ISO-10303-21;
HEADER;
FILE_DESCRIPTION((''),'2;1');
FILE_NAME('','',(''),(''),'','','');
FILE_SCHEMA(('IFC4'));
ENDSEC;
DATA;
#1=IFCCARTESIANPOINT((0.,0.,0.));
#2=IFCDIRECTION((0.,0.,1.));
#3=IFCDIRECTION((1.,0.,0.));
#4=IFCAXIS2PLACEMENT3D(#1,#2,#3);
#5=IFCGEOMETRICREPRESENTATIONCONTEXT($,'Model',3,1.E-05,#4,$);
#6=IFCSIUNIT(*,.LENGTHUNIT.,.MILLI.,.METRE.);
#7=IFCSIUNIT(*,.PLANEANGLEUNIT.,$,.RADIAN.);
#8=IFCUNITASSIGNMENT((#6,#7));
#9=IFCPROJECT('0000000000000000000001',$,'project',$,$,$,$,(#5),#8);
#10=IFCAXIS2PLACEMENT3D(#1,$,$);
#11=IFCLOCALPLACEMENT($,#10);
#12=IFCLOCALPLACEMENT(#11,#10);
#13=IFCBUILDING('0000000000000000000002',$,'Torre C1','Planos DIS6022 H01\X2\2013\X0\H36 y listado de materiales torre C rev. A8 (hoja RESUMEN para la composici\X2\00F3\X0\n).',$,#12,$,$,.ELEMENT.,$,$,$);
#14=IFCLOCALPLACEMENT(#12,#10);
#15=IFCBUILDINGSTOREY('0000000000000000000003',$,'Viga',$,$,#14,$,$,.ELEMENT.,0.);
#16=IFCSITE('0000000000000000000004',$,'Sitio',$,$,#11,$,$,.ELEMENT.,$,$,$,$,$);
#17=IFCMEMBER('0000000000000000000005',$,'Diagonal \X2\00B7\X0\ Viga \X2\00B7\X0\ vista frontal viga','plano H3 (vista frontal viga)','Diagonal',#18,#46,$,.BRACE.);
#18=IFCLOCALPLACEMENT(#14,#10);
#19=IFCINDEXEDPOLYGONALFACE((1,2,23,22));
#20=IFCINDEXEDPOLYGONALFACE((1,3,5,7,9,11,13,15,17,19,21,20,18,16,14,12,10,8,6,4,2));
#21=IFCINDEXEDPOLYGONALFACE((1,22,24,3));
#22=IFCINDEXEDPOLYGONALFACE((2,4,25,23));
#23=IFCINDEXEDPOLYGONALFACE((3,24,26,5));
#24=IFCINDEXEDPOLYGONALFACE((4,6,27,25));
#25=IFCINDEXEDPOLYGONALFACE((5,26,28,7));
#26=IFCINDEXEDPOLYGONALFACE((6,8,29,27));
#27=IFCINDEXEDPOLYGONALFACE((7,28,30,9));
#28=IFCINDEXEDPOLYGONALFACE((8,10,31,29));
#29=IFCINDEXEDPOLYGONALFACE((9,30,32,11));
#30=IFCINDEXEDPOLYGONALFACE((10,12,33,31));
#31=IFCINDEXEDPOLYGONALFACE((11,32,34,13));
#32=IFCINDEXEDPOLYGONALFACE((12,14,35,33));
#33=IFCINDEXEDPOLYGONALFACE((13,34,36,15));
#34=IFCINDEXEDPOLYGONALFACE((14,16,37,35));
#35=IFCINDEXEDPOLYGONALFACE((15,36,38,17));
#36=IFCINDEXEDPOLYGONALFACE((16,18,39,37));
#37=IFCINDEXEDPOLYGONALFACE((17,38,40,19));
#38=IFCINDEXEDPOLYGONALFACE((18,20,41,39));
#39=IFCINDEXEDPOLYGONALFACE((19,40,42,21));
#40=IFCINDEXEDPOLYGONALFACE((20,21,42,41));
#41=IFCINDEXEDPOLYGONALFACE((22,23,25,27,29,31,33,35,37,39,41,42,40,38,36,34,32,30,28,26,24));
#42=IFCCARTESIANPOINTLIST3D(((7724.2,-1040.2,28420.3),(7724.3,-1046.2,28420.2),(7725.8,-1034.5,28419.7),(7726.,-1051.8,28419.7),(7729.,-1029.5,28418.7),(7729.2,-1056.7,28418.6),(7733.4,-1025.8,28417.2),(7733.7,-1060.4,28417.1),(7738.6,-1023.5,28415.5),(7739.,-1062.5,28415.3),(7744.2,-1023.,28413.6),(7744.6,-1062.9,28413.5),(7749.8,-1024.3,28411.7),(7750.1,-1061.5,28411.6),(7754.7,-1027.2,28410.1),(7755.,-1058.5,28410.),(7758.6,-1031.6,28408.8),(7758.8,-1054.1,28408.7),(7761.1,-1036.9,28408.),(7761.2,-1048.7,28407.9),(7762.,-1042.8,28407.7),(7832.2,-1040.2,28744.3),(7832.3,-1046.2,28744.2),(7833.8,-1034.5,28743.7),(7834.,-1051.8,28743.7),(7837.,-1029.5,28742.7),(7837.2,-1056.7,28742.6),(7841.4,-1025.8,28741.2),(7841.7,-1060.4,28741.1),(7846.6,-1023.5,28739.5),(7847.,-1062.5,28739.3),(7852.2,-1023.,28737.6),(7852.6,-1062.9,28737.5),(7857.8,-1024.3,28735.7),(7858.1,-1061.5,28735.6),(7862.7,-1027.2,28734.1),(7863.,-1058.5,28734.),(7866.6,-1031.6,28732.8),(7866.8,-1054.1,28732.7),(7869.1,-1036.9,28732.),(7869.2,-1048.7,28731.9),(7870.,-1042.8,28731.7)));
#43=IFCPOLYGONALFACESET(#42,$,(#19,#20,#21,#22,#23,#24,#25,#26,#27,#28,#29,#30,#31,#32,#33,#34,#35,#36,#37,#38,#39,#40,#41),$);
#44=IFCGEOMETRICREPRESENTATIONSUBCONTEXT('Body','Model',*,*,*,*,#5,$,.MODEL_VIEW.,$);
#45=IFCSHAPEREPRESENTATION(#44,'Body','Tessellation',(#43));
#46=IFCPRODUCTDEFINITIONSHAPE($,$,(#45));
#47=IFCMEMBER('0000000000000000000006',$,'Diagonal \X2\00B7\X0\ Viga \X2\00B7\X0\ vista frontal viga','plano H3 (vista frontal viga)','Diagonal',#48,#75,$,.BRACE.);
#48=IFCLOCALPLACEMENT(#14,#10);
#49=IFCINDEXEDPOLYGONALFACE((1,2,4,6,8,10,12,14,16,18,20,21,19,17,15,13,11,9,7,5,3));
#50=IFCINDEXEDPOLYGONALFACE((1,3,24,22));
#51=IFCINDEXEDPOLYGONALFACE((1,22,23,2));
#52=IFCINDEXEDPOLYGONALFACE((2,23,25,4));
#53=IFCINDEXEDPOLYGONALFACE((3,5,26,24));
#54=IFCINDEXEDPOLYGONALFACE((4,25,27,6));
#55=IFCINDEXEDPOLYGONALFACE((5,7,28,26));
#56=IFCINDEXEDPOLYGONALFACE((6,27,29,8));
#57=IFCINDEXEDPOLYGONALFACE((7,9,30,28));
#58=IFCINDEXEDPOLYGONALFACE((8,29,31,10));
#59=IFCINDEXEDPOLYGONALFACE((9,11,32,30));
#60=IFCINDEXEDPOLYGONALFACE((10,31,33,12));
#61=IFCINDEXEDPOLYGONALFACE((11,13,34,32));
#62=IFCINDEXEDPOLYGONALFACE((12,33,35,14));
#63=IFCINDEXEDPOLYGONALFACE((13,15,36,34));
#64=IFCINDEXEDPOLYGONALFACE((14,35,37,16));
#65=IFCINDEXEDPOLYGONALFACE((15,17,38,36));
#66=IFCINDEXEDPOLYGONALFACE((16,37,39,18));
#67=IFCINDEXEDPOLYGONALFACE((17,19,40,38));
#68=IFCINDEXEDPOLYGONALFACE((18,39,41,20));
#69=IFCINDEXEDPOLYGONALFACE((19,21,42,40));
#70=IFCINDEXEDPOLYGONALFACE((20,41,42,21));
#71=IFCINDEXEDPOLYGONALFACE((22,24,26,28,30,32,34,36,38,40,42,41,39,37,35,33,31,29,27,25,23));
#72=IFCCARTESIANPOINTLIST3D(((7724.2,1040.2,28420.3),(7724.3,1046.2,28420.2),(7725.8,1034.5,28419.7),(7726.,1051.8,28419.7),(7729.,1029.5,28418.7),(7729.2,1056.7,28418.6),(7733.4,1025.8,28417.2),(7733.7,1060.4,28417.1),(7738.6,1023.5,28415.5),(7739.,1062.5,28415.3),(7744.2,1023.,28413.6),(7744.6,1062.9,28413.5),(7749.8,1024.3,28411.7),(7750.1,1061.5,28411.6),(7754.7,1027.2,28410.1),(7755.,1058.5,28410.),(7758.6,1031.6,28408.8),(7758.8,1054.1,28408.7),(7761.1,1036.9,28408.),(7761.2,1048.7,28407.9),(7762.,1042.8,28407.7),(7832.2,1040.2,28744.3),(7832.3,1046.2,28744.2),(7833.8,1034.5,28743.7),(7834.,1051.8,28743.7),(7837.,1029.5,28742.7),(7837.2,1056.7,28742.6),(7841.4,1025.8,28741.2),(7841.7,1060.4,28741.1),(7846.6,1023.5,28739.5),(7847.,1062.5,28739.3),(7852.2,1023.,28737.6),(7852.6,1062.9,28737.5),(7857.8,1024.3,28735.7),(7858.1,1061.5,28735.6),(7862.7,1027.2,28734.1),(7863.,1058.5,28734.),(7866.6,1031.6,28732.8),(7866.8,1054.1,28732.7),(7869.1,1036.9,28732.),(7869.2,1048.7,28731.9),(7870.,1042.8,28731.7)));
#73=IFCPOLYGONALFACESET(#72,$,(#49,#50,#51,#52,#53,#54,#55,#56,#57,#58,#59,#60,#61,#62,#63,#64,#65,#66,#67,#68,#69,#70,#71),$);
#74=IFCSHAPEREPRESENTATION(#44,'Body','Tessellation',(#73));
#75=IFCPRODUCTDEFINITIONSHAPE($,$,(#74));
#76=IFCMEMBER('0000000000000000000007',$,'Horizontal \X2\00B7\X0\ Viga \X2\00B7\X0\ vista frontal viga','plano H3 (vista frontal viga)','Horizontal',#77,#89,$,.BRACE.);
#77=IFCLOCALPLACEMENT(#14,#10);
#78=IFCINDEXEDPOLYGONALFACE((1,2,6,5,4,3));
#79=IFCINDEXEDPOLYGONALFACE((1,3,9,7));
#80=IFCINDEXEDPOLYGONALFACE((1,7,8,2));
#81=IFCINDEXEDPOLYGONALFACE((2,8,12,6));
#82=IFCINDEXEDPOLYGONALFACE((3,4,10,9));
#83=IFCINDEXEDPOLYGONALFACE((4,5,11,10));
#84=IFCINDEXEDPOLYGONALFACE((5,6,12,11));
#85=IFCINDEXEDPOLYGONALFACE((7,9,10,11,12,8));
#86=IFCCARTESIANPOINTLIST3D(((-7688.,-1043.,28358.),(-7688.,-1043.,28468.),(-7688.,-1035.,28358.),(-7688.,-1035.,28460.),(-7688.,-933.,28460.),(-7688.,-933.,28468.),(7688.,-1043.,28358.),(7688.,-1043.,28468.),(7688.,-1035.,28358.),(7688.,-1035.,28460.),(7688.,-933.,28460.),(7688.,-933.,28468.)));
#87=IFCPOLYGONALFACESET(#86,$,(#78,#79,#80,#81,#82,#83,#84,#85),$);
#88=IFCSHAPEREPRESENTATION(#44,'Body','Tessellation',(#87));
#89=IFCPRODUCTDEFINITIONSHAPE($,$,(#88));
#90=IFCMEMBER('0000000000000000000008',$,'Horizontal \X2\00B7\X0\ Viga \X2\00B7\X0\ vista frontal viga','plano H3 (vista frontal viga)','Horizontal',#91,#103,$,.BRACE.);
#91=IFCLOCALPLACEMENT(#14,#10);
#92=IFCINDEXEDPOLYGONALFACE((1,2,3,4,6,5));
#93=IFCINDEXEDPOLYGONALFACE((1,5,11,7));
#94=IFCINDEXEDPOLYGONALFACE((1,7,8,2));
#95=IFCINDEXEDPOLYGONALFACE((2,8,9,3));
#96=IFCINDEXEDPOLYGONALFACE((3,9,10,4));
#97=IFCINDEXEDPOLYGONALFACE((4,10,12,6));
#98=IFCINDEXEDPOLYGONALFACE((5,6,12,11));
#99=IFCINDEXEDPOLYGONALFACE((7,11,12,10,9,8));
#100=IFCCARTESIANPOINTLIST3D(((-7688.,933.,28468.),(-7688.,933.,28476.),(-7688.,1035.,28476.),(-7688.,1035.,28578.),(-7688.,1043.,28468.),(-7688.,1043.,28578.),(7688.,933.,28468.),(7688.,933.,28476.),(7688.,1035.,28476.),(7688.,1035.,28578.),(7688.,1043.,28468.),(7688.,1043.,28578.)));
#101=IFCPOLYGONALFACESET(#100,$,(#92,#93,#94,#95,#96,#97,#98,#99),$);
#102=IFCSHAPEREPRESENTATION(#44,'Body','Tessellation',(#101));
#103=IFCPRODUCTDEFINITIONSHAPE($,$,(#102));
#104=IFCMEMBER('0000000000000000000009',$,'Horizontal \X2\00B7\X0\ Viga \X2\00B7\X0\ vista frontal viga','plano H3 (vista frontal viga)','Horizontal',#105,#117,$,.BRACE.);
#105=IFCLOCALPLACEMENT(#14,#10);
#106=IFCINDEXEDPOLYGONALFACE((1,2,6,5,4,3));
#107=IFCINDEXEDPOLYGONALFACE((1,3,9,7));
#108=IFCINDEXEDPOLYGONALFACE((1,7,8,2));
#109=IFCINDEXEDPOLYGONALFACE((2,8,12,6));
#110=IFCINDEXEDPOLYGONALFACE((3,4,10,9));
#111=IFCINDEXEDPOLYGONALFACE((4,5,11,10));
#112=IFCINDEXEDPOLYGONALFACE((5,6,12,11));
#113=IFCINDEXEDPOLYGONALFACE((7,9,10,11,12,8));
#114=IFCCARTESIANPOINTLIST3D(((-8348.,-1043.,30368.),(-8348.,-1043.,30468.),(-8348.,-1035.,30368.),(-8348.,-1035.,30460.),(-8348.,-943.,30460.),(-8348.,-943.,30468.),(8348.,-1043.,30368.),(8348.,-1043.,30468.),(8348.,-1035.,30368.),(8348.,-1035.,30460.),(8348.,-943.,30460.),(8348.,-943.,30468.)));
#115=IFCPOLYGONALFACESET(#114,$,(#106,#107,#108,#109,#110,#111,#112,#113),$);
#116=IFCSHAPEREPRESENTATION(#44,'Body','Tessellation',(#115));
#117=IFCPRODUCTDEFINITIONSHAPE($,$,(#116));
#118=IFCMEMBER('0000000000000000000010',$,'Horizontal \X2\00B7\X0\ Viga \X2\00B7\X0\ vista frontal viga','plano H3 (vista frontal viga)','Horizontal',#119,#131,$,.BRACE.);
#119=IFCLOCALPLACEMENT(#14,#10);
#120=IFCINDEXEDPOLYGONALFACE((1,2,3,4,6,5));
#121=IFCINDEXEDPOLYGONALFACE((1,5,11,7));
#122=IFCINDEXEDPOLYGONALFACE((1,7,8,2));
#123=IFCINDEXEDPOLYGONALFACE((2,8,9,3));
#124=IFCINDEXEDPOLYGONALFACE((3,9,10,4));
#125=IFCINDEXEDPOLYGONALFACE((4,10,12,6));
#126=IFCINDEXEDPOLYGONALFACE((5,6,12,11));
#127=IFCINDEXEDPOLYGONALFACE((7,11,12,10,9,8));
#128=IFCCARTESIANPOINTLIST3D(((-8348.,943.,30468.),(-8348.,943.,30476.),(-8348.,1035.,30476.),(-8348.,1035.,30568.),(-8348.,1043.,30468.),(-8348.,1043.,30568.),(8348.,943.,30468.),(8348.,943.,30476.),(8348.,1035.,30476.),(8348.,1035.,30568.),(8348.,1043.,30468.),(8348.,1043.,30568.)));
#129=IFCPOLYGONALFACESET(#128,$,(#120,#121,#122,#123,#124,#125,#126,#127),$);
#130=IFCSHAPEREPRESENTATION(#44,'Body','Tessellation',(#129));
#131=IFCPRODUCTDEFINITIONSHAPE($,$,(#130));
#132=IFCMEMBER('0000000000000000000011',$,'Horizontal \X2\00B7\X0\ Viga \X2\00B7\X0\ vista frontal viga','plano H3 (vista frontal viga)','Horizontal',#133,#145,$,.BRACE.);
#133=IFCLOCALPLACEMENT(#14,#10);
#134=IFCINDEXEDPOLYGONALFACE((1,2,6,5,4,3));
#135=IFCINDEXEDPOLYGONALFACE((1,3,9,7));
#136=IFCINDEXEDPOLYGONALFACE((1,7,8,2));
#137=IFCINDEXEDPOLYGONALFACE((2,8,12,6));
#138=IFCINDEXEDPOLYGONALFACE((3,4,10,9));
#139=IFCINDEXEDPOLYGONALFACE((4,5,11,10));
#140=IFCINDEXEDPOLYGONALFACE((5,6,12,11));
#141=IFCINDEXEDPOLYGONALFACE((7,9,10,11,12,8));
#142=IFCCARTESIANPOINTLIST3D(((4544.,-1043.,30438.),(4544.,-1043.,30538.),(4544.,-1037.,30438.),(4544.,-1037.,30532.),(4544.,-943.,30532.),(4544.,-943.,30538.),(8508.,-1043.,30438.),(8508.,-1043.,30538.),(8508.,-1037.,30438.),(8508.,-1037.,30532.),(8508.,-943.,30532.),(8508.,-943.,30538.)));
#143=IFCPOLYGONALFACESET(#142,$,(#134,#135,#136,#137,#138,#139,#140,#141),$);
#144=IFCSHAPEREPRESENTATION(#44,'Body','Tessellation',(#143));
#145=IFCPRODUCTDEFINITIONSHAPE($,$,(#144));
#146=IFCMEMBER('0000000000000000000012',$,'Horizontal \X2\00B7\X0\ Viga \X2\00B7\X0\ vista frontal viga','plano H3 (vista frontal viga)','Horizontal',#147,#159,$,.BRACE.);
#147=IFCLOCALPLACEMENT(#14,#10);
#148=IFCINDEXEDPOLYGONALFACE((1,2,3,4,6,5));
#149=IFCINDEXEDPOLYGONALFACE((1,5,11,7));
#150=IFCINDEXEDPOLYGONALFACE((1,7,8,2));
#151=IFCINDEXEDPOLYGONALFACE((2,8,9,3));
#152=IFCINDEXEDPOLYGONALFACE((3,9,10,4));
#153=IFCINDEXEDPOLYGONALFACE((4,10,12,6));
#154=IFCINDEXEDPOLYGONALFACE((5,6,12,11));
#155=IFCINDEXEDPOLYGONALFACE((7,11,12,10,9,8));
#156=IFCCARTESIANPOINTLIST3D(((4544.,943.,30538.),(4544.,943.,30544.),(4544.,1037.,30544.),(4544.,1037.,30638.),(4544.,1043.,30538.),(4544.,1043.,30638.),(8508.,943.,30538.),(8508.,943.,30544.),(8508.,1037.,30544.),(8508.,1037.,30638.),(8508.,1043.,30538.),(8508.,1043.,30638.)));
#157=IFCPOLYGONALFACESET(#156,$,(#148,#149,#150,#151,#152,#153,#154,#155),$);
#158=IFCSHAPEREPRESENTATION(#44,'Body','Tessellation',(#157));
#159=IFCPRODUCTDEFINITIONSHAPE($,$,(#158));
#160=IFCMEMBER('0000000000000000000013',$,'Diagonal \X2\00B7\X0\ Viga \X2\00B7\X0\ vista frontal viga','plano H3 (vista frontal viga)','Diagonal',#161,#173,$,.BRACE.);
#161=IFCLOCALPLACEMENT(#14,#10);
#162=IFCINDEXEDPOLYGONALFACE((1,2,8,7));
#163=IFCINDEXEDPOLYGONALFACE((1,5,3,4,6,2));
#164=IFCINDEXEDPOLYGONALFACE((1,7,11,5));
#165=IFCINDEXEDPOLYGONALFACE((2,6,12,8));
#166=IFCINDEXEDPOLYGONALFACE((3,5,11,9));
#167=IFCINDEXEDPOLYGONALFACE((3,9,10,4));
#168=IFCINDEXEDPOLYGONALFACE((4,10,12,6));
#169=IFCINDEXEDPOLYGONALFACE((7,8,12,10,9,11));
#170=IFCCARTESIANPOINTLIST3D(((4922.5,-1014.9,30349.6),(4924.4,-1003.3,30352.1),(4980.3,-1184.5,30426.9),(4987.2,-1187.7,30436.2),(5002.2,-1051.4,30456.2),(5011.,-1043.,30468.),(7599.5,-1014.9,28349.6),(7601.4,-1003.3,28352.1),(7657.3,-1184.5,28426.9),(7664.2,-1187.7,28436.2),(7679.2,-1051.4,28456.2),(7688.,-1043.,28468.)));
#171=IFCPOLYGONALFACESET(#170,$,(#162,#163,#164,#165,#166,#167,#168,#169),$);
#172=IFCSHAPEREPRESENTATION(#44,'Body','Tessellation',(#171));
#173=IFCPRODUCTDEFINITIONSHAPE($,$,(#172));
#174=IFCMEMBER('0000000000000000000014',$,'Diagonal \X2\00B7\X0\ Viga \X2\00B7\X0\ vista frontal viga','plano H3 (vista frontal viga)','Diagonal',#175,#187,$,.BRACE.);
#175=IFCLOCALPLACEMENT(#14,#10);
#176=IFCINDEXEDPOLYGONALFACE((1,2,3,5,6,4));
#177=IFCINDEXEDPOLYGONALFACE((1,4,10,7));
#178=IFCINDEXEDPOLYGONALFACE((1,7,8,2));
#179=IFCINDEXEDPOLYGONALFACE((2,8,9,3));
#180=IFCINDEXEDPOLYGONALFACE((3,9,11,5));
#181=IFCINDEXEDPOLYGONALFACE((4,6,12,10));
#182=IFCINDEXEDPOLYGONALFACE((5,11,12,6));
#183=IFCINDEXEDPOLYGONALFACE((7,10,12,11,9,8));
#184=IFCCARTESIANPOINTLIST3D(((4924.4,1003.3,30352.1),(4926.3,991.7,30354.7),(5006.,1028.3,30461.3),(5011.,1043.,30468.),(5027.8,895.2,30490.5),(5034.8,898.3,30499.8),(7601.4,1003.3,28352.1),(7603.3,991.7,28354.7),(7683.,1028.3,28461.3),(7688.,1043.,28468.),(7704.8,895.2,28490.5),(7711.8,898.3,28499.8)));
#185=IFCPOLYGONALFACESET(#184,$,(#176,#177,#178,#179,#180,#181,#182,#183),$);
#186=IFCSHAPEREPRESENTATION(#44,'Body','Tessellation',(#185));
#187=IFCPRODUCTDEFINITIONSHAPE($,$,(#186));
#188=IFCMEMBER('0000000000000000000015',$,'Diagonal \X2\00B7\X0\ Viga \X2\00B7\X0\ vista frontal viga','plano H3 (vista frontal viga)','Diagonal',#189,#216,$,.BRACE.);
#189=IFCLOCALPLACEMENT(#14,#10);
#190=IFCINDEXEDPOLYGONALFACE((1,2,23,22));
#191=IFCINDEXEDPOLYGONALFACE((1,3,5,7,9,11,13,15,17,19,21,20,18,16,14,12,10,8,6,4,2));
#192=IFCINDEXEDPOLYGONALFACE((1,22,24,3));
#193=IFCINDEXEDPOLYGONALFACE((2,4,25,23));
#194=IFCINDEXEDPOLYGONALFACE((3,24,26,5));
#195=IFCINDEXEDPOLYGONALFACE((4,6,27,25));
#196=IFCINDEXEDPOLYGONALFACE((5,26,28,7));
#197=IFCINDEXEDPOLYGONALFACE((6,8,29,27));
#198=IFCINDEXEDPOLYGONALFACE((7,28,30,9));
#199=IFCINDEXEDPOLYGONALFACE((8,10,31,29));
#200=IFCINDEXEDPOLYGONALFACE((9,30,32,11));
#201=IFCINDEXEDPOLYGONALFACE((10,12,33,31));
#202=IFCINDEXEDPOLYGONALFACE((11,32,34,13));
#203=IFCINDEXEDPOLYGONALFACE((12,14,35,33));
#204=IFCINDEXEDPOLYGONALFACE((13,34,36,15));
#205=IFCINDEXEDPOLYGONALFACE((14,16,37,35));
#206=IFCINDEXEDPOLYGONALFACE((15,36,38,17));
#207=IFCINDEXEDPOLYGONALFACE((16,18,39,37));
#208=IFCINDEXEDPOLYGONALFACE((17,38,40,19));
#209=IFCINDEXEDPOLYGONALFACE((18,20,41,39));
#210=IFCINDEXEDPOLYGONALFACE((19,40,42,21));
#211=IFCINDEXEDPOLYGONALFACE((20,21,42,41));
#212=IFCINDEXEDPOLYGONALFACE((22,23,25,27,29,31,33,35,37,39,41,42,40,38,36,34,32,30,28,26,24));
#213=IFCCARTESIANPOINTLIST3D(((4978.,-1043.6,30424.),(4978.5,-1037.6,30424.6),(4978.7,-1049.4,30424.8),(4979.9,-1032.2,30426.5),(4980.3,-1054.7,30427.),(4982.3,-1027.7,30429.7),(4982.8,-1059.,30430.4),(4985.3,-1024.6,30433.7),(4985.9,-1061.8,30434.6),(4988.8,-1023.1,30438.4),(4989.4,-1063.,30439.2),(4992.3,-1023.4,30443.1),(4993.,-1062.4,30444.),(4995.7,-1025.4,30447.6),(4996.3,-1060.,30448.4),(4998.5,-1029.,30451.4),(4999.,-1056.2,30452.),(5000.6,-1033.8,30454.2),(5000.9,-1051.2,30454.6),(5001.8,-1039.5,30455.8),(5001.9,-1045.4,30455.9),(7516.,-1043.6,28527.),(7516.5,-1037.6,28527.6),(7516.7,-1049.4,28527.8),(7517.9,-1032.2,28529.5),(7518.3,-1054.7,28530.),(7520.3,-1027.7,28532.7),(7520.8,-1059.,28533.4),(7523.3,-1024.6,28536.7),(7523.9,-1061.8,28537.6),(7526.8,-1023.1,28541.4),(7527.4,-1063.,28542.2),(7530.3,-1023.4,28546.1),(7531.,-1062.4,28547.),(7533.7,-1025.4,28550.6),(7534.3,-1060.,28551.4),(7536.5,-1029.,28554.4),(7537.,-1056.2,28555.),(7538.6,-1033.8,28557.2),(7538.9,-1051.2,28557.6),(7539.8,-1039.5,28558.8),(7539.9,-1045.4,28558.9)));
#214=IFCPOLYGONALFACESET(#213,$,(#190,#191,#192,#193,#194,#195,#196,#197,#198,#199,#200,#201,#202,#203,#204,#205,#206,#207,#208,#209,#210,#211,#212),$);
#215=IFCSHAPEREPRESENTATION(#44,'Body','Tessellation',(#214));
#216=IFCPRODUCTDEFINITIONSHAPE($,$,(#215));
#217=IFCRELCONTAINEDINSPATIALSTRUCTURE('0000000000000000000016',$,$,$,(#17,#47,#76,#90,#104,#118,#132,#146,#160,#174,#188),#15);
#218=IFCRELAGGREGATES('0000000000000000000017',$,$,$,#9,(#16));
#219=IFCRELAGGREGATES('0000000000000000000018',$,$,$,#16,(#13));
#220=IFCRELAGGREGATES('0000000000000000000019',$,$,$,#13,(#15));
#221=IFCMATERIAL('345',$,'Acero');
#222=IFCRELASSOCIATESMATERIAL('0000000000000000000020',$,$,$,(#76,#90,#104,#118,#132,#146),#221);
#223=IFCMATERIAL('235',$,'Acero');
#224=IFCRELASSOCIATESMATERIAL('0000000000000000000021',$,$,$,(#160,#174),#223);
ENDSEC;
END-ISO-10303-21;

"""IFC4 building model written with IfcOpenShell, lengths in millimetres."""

from ifc_helpers import new_model, si_unit, frame, frame_2d, origin, origin_with_axes, place, context, subcontext, project, spatial, circle, l_section, extrude, material, element, save


model = new_model("IFC4")

# Units and contexts
model_context = context("Model", 3, precision=1e-05, world=origin_with_axes())
body_context = subcontext(model_context, "Body", "Model", "MODEL_VIEW")
ifc_project = project(units=[si_unit("LENGTHUNIT", "METRE", prefix="MILLI"), si_unit("PLANEANGLEUNIT", "RADIAN")], contexts=[model_context])

# Site, building, storey
site_placement = place(None, origin())
site = spatial("IfcSite", under=ifc_project, at=site_placement, Name="Sitio", CompositionType="ELEMENT")
building_placement = place(site_placement, origin())
building = spatial("IfcBuilding", under=site, at=building_placement, Name="Torre C1", Description="Planos DIS6022 H01–H36 y listado de materiales torre C rev. A8 (hoja RESUMEN para la composición).", CompositionType="ELEMENT")
storey_placement = place(building_placement, origin())
storey = spatial("IfcBuildingStorey", under=building, at=storey_placement, Name="Viga", CompositionType="ELEMENT", Elevation=0.0)

# Members
for number, where, z_axis, x_axis, name in (
    (1, (7743.0, -1043.0, 28414.0), (0.316228, 0.0, 0.948683), (-0.939391, 0.139624, 0.31313), "Diagonal · Viga · vista frontal viga"),
    (2, (7743.0, 1043.0, 28414.0), (0.316228, 0.0, 0.948683), (-0.939391, -0.139624, 0.31313), "Diagonal · Viga · vista frontal viga"),
):
    element("IfcMember", number, at=place(storey_placement, frame(where, z_axis=z_axis, x_axis=x_axis)), inside=storey, Name=name, Description="plano H3 (vista frontal viga)", ObjectType="Diagonal", PredefinedType="BRACE", context=body_context, shape_type="SweptSolid", body=[
        extrude(circle(Radius=20.0), None, (0.0, 0.0, 1.0), 341.5),
    ])
ifc_material_1 = material(Name="345", Category="Acero")
for number, where, z_axis, x_axis, name in (
    (3, (7688.0, -1043.0, 28468.0), (-1.0, 0.0, 0.0), (0.0, 1.0, 0.0), "Horizontal · Viga · vista frontal viga"),
    (4, (7688.0, 1043.0, 28468.0), (-1.0, 0.0, 0.0), (0.0, -1.0, 0.0), "Horizontal · Viga · vista frontal viga"),
):
    element("IfcMember", number, at=place(storey_placement, frame(where, z_axis=z_axis, x_axis=x_axis)), inside=storey, material=ifc_material_1, Name=name, Description="plano H3 (vista frontal viga)", ObjectType="Horizontal", PredefinedType="BRACE", context=body_context, shape_type="SweptSolid", body=[
        extrude(l_section(Depth=110.0, Width=110.0, Thickness=8.0, at=frame_2d((55.0, 55.0))), None, (0.0, 0.0, 1.0), 15376.0),
    ])
for number, where, z_axis, x_axis, name in (
    (5, (8348.0, -1043.0, 30468.0), (-1.0, 0.0, 0.0), (0.0, 1.0, 0.0), "Horizontal · Viga · vista frontal viga"),
    (6, (8348.0, 1043.0, 30468.0), (-1.0, 0.0, 0.0), (0.0, -1.0, 0.0), "Horizontal · Viga · vista frontal viga"),
):
    element("IfcMember", number, at=place(storey_placement, frame(where, z_axis=z_axis, x_axis=x_axis)), inside=storey, material=ifc_material_1, Name=name, Description="plano H3 (vista frontal viga)", ObjectType="Horizontal", PredefinedType="BRACE", context=body_context, shape_type="SweptSolid", body=[
        extrude(l_section(Depth=100.0, Width=100.0, Thickness=8.0, at=frame_2d((50.0, 50.0))), None, (0.0, 0.0, 1.0), 16696.0),
    ])
for number, where, z_axis, x_axis, name in (
    (7, (8508.0, -1043.0, 30538.0), (-1.0, 0.0, 0.0), (0.0, 1.0, 0.0), "Horizontal · Viga · vista frontal viga"),
    (8, (8508.0, 1043.0, 30538.0), (-1.0, 0.0, 0.0), (0.0, -1.0, 0.0), "Horizontal · Viga · vista frontal viga"),
):
    element("IfcMember", number, at=place(storey_placement, frame(where, z_axis=z_axis, x_axis=x_axis)), inside=storey, material=ifc_material_1, Name=name, Description="plano H3 (vista frontal viga)", ObjectType="Horizontal", PredefinedType="BRACE", context=body_context, shape_type="SweptSolid", body=[
        extrude(l_section(Depth=100.0, Width=100.0, Thickness=6.0, at=frame_2d((50.0, 50.0))), None, (0.0, 0.0, 1.0), 3964.0),
    ])
ifc_material_2 = material(Name="235", Category="Acero")
for number, where, z_axis, x_axis, name in (
    (9, (7688.0, -1043.0, 28468.0), (-0.801112, 0.0, 0.598515), (-0.577172, 0.264667, -0.772544), "Diagonal · Viga · vista frontal viga"),
    (10, (7688.0, 1043.0, 28468.0), (-0.801112, 0.0, 0.598515), (-0.577172, -0.264667, -0.772544), "Diagonal · Viga · vista frontal viga"),
):
    element("IfcMember", number, at=place(storey_placement, frame(where, z_axis=z_axis, x_axis=x_axis)), inside=storey, material=ifc_material_2, Name=name, Description="plano H3 (vista frontal viga)", ObjectType="Diagonal", PredefinedType="BRACE", context=body_context, shape_type="SweptSolid", body=[
        extrude(l_section(Depth=150.0, Width=150.0, Thickness=12.0, at=frame_2d((75.0, 75.0))), None, (0.0, 0.0, 1.0), 3341.6),
    ])
for number, where, z_axis, x_axis, name in (
    (11, (7528.0, -1043.0, 28543.0), (-0.800984, 0.0, 0.598686), (-0.576761, 0.268149, -0.771649), "Diagonal · Viga · vista frontal viga"),
):
    element("IfcMember", number, at=place(storey_placement, frame(where, z_axis=z_axis, x_axis=x_axis)), inside=storey, Name=name, Description="plano H3 (vista frontal viga)", ObjectType="Diagonal", PredefinedType="BRACE", context=body_context, shape_type="SweptSolid", body=[
        extrude(circle(Radius=20.0), None, (0.0, 0.0, 1.0), 3168.6),
    ])

save(model, "model.ifc")
